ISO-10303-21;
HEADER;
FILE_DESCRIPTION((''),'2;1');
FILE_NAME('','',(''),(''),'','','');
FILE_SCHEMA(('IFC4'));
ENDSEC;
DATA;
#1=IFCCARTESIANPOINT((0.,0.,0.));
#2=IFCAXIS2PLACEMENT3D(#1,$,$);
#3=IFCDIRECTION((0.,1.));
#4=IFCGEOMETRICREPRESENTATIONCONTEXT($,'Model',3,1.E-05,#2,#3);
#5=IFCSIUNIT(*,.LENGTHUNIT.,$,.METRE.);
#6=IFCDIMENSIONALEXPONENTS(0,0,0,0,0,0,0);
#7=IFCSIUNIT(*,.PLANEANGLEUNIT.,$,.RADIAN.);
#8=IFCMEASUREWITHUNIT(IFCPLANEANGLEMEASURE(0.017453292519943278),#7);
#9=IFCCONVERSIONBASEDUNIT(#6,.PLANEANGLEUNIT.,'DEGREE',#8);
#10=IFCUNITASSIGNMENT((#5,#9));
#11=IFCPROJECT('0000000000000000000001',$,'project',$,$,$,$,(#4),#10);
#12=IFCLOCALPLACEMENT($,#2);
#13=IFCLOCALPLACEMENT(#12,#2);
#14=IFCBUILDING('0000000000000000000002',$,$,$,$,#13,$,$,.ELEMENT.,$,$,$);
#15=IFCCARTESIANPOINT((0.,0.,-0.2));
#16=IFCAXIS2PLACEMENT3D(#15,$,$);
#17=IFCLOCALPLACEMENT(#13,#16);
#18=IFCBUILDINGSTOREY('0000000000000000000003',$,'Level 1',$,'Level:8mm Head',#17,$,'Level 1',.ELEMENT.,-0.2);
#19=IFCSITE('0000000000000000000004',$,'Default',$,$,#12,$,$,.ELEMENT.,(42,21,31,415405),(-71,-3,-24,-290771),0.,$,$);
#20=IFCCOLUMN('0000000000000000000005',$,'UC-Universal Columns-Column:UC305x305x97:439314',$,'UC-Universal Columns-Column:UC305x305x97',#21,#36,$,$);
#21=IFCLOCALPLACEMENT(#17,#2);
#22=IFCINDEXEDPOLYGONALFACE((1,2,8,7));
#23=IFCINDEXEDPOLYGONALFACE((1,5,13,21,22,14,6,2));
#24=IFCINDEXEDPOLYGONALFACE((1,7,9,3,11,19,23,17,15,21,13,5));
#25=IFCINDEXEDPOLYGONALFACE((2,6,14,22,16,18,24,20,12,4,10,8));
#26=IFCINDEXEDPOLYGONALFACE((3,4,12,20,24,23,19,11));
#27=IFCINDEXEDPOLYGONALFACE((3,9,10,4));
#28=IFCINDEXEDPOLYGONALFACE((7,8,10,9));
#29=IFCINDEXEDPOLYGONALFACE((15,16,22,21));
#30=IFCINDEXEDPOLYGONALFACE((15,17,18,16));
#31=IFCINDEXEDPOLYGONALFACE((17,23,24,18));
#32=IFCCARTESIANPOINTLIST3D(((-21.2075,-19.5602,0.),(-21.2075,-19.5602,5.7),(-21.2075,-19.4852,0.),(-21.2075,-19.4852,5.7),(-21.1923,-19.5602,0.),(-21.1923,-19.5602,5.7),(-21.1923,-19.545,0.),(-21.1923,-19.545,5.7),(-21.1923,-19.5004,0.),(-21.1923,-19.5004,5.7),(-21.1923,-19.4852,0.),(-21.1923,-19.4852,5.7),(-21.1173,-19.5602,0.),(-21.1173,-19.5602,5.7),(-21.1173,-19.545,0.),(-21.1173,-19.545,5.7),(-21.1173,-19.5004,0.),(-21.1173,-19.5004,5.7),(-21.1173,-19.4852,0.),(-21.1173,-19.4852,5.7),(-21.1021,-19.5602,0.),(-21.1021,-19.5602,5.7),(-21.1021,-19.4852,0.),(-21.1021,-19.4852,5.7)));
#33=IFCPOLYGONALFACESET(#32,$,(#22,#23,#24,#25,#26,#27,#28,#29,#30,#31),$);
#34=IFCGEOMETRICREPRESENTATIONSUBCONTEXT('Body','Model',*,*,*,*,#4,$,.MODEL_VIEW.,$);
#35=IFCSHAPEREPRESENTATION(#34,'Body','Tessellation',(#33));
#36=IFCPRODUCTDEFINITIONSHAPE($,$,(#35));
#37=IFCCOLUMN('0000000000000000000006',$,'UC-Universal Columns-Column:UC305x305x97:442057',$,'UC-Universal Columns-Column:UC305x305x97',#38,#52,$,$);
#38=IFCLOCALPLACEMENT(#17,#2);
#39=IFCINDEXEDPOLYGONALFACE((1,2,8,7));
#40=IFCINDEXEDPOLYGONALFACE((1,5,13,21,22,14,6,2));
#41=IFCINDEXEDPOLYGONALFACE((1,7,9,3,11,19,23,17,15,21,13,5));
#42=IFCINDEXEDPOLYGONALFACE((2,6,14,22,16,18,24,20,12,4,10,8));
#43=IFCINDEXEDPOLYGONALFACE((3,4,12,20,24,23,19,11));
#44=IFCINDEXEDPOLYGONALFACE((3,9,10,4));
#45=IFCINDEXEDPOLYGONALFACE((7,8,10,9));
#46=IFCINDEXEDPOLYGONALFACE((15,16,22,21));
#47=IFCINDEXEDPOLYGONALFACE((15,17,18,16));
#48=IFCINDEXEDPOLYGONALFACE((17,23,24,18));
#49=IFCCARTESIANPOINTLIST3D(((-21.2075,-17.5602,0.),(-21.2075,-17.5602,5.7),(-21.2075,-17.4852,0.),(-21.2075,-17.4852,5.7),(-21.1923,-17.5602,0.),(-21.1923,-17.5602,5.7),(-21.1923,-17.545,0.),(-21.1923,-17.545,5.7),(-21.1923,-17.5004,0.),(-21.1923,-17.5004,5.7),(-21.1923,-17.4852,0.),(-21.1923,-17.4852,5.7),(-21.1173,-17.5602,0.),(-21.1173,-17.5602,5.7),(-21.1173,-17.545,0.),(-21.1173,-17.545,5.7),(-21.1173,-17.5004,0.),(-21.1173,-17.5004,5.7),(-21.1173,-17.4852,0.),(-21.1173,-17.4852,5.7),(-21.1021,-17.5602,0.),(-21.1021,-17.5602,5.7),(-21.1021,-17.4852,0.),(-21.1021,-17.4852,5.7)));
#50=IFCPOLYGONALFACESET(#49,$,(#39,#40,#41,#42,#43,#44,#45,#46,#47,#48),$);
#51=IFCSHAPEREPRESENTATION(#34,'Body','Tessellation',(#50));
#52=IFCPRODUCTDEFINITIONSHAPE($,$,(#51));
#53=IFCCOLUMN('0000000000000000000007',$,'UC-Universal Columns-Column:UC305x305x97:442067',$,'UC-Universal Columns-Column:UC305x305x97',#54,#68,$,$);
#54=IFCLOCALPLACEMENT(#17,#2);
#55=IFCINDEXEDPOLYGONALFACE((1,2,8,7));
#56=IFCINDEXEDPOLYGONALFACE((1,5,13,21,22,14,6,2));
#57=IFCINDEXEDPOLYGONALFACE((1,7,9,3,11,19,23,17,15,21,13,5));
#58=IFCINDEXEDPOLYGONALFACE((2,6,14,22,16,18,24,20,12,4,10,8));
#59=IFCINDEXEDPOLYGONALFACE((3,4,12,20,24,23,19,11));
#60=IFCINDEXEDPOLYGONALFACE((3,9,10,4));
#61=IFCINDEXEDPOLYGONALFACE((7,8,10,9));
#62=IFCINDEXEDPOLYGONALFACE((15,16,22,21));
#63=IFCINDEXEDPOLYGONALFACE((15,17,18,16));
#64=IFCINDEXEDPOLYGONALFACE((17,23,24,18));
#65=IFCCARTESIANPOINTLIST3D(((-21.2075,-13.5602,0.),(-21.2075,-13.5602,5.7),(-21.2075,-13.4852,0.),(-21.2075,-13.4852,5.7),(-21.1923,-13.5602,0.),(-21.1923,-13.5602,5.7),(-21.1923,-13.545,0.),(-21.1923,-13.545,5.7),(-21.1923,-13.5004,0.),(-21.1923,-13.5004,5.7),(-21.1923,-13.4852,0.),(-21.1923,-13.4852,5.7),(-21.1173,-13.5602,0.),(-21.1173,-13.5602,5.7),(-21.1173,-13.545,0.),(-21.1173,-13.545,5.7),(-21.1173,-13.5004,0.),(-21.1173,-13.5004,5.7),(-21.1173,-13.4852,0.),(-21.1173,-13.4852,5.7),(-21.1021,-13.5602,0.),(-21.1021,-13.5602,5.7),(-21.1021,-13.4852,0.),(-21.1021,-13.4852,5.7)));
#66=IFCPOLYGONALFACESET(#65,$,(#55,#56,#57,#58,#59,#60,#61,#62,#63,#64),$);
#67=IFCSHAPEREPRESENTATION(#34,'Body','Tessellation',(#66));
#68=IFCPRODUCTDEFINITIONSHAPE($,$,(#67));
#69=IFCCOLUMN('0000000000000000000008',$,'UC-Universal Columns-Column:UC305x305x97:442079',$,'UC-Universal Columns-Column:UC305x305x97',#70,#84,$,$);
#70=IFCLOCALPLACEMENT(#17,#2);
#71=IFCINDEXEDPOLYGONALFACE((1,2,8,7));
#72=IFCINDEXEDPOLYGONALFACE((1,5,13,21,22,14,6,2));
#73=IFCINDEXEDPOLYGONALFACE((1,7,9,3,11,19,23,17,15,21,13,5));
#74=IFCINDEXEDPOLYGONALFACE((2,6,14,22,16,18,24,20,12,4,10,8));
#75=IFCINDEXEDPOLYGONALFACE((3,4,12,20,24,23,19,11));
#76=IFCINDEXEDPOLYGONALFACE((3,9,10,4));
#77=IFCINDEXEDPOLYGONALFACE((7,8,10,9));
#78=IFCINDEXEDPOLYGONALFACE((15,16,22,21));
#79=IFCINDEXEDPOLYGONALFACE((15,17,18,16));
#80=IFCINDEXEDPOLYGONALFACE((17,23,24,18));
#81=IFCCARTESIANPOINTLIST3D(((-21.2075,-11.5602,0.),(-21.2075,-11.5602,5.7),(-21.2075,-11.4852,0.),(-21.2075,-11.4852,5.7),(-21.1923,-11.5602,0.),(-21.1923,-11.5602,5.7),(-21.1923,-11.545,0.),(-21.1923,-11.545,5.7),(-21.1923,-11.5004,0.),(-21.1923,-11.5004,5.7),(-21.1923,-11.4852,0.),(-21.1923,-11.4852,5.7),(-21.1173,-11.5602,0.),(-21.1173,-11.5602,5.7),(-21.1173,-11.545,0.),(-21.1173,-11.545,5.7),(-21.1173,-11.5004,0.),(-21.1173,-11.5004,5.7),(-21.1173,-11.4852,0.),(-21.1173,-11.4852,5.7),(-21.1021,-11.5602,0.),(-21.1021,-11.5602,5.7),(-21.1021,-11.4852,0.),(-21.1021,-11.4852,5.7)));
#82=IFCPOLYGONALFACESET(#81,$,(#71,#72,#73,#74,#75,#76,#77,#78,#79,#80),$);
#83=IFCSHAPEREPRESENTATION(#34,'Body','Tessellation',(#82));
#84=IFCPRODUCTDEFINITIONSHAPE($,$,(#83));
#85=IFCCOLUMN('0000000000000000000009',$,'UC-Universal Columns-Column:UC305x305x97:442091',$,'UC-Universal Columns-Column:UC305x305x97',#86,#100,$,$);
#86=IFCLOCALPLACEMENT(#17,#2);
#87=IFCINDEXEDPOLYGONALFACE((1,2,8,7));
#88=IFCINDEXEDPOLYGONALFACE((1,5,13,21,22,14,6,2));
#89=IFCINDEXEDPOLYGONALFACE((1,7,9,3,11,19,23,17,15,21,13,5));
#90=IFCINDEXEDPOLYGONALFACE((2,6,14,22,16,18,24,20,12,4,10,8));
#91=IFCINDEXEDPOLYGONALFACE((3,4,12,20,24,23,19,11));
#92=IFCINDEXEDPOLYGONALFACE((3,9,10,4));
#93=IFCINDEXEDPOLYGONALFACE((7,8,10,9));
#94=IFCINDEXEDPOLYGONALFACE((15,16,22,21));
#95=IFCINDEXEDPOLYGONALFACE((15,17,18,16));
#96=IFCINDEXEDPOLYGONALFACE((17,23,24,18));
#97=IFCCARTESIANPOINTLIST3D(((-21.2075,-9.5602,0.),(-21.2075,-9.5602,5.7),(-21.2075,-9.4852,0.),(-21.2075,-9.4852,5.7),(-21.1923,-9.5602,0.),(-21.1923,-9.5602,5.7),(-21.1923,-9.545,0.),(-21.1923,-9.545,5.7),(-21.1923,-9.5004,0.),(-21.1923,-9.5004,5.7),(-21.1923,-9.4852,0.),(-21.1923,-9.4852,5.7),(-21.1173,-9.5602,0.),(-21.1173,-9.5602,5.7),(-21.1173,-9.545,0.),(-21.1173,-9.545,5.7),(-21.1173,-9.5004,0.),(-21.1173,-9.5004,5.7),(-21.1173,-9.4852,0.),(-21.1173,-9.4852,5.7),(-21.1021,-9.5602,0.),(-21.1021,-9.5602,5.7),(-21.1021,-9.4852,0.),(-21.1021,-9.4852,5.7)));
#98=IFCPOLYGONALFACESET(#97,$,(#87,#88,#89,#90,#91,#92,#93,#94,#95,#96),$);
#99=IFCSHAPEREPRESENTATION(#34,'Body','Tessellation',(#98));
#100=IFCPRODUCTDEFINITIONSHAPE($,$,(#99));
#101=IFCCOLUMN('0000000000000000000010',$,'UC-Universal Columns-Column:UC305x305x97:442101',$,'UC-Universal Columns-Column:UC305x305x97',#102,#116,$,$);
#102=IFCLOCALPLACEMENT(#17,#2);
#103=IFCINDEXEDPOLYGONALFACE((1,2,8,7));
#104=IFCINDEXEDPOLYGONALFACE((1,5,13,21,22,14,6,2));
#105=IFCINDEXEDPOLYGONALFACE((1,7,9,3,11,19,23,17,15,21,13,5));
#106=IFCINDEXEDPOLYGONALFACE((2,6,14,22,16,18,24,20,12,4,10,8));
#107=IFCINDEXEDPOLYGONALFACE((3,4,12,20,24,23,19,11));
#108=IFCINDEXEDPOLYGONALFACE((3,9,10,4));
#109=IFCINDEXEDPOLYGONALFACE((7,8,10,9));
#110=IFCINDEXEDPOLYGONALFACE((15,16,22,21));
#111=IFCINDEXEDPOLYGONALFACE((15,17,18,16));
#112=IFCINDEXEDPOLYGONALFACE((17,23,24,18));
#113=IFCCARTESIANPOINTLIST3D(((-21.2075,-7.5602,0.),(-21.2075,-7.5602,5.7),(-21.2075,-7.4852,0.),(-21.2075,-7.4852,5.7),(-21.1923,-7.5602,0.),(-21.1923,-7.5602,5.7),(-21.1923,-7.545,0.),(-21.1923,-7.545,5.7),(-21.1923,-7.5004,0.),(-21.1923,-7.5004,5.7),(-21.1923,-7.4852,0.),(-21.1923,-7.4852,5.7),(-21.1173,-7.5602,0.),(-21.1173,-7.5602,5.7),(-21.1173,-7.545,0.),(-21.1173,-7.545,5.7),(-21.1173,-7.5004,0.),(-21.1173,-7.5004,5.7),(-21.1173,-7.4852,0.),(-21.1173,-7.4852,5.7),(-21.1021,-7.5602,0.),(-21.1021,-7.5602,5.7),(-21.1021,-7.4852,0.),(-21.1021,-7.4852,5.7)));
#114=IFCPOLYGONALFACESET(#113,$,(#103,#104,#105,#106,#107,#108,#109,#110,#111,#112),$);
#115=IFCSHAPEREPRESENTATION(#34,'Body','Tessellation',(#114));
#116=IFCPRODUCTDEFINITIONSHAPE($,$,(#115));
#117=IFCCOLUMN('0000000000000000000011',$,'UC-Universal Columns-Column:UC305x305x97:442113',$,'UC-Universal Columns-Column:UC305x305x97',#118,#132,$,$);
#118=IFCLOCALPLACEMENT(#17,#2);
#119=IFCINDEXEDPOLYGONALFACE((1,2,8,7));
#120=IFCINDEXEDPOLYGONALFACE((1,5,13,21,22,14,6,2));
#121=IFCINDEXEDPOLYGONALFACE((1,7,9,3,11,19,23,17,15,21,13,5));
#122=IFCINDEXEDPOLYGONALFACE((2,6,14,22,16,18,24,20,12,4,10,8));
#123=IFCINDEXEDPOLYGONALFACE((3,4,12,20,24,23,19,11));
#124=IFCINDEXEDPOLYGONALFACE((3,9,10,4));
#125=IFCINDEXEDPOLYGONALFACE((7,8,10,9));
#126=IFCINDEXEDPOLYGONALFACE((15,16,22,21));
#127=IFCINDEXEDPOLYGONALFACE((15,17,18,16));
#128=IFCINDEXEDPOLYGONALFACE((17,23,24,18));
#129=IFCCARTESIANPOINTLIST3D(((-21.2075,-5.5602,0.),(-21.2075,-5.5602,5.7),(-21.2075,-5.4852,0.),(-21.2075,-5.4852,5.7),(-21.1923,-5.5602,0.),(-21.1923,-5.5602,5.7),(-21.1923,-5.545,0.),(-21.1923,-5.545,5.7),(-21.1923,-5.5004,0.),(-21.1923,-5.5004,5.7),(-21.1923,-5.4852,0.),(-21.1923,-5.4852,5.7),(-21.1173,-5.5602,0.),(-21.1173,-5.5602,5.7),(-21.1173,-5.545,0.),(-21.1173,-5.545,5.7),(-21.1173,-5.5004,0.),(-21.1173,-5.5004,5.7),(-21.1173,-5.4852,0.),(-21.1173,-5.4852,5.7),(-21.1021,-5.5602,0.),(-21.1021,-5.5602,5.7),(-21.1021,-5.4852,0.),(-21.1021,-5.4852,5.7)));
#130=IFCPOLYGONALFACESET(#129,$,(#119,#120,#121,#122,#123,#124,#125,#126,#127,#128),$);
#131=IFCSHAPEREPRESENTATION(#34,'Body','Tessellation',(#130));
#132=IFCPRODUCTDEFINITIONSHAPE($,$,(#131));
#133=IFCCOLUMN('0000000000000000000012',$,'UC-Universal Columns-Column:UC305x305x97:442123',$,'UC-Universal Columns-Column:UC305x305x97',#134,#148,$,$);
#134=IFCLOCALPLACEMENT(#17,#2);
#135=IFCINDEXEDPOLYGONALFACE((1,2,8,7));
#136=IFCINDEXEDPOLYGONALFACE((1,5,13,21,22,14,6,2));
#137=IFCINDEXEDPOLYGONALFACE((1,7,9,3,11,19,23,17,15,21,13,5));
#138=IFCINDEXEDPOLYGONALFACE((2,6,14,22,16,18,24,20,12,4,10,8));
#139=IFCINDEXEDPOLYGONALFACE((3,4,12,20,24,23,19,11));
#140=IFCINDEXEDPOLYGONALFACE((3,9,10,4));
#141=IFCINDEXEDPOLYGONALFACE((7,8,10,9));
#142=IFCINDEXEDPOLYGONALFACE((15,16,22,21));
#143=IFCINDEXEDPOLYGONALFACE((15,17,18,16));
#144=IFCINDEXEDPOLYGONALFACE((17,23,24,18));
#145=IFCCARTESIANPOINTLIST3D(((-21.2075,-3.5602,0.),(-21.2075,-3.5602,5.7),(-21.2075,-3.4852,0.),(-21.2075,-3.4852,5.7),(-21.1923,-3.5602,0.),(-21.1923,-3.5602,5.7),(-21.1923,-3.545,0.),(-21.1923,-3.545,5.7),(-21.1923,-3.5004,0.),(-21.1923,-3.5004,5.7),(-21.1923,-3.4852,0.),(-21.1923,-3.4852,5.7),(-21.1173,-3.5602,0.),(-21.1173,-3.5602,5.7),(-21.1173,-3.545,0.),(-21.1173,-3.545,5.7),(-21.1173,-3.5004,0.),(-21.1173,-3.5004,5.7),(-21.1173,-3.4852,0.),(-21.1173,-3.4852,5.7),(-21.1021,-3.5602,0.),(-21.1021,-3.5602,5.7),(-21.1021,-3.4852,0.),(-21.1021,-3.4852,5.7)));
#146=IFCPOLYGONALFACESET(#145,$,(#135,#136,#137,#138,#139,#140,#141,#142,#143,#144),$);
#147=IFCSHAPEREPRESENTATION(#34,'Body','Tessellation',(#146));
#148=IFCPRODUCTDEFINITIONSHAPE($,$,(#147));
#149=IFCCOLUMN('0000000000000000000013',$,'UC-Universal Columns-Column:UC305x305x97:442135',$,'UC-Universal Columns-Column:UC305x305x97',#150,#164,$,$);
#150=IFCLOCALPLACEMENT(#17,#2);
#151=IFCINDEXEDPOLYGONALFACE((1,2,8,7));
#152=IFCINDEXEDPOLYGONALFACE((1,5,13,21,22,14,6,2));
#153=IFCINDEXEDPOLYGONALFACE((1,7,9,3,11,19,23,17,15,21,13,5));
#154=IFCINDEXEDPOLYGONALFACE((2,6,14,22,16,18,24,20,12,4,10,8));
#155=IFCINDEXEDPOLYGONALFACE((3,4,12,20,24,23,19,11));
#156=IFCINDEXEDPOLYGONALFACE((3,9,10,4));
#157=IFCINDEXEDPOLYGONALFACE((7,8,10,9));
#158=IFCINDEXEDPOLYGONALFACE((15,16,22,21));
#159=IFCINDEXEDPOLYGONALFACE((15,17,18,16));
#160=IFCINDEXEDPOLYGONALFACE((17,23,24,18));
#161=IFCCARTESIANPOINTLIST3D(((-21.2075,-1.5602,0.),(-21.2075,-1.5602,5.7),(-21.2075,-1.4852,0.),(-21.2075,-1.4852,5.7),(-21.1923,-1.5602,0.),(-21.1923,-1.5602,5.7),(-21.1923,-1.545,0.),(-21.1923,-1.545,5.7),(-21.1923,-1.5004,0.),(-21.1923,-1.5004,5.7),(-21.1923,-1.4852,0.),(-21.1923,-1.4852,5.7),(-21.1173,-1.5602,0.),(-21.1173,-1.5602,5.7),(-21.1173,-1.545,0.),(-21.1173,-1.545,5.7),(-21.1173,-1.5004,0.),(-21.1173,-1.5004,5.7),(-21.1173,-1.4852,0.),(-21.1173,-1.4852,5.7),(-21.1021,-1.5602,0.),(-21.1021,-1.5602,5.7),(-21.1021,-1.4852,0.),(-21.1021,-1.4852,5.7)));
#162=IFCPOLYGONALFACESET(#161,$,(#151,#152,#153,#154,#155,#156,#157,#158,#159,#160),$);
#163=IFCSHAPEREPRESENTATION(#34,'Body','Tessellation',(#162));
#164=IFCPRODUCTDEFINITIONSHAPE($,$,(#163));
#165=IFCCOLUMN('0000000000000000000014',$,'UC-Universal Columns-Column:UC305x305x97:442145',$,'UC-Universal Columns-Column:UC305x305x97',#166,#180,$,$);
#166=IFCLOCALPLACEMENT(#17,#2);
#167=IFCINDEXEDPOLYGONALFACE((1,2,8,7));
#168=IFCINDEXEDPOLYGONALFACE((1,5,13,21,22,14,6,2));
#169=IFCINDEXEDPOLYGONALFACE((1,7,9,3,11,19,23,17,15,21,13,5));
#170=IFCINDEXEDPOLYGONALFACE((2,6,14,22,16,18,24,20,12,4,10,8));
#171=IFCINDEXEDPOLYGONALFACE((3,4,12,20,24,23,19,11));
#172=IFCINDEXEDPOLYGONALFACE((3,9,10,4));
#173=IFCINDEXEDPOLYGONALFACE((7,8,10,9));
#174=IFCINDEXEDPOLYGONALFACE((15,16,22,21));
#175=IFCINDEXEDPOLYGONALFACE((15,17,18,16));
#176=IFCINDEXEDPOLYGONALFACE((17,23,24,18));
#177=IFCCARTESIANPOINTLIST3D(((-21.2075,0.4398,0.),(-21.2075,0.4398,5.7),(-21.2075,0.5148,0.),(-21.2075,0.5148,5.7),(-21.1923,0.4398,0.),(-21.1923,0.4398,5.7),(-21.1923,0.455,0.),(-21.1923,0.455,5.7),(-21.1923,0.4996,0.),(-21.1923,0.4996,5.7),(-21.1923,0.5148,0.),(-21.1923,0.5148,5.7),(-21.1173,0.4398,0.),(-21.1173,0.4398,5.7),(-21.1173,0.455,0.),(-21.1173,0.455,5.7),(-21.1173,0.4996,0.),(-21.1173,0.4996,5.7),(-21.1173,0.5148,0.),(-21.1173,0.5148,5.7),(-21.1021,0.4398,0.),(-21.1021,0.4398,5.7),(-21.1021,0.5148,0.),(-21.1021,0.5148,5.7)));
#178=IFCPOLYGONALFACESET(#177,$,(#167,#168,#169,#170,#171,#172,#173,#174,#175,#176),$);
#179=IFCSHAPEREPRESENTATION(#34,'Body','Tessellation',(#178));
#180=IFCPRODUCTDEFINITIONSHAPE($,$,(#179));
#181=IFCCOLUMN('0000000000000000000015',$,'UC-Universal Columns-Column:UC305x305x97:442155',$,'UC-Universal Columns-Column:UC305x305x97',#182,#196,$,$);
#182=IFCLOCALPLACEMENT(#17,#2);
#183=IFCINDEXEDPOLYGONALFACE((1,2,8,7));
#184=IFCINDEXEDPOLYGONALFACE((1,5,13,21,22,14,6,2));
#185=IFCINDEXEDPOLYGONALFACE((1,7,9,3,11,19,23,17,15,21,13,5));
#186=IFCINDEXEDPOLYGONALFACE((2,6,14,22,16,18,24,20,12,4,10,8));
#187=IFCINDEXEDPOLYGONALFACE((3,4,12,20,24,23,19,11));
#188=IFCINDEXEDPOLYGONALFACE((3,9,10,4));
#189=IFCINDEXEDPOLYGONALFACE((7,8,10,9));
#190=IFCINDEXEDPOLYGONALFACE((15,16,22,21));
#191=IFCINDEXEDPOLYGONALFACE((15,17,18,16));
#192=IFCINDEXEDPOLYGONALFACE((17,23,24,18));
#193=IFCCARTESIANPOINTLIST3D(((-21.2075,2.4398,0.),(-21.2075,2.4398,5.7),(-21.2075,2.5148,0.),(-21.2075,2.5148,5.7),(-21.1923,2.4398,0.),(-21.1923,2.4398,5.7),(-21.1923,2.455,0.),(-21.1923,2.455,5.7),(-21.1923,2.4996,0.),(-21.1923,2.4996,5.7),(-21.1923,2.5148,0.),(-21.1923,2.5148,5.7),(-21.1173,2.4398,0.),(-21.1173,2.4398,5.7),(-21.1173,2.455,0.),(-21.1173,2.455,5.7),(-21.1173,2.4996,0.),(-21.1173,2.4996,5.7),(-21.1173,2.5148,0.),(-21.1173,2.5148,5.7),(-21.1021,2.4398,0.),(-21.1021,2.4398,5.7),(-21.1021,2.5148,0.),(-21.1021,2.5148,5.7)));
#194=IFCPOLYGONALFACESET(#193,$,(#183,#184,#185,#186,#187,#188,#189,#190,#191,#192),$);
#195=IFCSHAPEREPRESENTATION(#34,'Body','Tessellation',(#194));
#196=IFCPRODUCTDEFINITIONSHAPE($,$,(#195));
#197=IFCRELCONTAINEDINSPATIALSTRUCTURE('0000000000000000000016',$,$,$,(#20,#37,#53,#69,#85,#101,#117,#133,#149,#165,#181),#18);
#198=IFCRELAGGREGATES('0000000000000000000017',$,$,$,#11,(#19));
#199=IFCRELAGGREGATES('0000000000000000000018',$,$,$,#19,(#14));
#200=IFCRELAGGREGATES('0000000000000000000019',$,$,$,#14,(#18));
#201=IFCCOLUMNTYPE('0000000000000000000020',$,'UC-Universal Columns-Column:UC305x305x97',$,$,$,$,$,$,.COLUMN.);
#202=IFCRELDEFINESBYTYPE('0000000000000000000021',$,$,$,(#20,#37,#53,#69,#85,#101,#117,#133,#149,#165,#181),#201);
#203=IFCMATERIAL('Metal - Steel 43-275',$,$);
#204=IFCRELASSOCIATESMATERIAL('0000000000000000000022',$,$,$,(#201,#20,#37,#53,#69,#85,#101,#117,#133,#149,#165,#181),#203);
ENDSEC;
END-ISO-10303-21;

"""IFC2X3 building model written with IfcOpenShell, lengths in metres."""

from ifc_helpers import new_model, entity, si_unit, converted_unit, direction, frame, frame_2d, origin, place, context, subcontext, project, spatial, polyline, circle_curve, parameter, trimmed, segment, composite_curve, outline, extrude, source, transform, mapped, material, type_object, type_shapes, element, save


model = new_model("IFC2X3")

# Units and contexts
model_context = context("Model", 3, precision=1e-05, world=origin(), true_north=direction((0.0, 1.0)))
body_context = subcontext(model_context, "Body", "Model", "MODEL_VIEW")
ifc_project = project(units=[si_unit("LENGTHUNIT", "METRE"), converted_unit("PLANEANGLEUNIT", "DEGREE", entity("IfcPlaneAngleMeasure", 0.017453292519943278), si_unit("PLANEANGLEUNIT", "RADIAN"), dimensions=[0, 0, 0, 0, 0, 0, 0])], contexts=[model_context])

# Site, building, storey
site_placement = place(None, origin())
site = spatial("IfcSite", under=ifc_project, at=site_placement, Name="Default", CompositionType="ELEMENT", RefLatitude=(42, 21, 31, 415405), RefLongitude=(-71, -3, -24, -290771), RefElevation=0.0)
building_placement = place(site_placement, origin())
building = spatial("IfcBuilding", under=site, at=building_placement, CompositionType="ELEMENT")
storey_placement = place(building_placement, frame((0.0, 0.0, -0.2)))
storey = spatial("IfcBuildingStorey", under=building, at=storey_placement, Name="Level 1", ObjectType="Level:8mm Head", LongName="Level 1", CompositionType="ELEMENT", Elevation=-0.2)

# Columns
ifc_material_1 = material(Name="Metal - Steel 43-275")
column_type_1 = type_object("IfcColumnType", Name="UC-Universal Columns-Column:UC305x305x97", PredefinedType="COLUMN", material=ifc_material_1)
shared_shape_1 = source(origin(), body_context, "Body", "SweptSolid", [
    extrude(outline(composite_curve([segment(polyline([(-0.0375, -0.0375), (0.0375, -0.0375)]), True, "CONTINUOUS"), segment(polyline([(0.0375, -0.0375), (0.0527, -0.0375)]), True, "CONTINUOUS"), segment(trimmed(circle_curve(frame_2d((0.0527, -0.0223), x_axis=(-1.0, 0.0)), 0.0152), [parameter(0.0)], [parameter(90.0)], True, "PARAMETER"), False, "CONTINUOUS"), segment(polyline([(0.0375, -0.0223), (0.0375, 0.0223)]), True, "CONTINUOUS"), segment(trimmed(circle_curve(frame_2d((0.0527, 0.0223), x_axis=(-1.0, 0.0)), 0.0152), [parameter(270.0)], [parameter(0.0)], True, "PARAMETER"), False, "CONTINUOUS"), segment(polyline([(0.0527, 0.0375), (0.0375, 0.0375)]), True, "CONTINUOUS"), segment(polyline([(0.0375, 0.0375), (-0.0375, 0.0375)]), True, "CONTINUOUS"), segment(polyline([(-0.0375, 0.0375), (-0.0527, 0.0375)]), True, "CONTINUOUS"), segment(trimmed(circle_curve(frame_2d((-0.0527, 0.0223), x_axis=(-1.0, 0.0)), 0.0152), [parameter(180.0)], [parameter(270.0)], True, "PARAMETER"), False, "CONTINUOUS"), segment(polyline([(-0.0375, 0.0223), (-0.0375, -0.0223)]), True, "CONTINUOUS"), segment(trimmed(circle_curve(frame_2d((-0.0527, -0.0223), x_axis=(-1.0, 0.0)), 0.0152), [parameter(90.0)], [parameter(180.0)], True, "PARAMETER"), False, "CONTINUOUS"), segment(polyline([(-0.0527, -0.0375), (-0.0375, -0.0375)]), True, "CONTINUOUS")], self_intersect=False)), frame((0.0, 0.0, -0.2), z_axis=(0.0, 0.0, 1.0), x_axis=(-1.0, 0.0, 0.0)), (0.0, 0.0, 1.0), 5.7),
])
type_shapes(column_type_1, [shared_shape_1])
for number, where, z_axis, x_axis, name in (
    (1, (-21.1548, -19.5227, 0.2), (0.0, 0.0, 1.0), (-1.0, 0.0, 0.0), "UC-Universal Columns-Column:UC305x305x97:439314"),
    (2, (-21.1548, -17.5227, 0.2), (0.0, 0.0, 1.0), (-1.0, 0.0, 0.0), "UC-Universal Columns-Column:UC305x305x97:442057"),
    (3, (-21.1548, -13.5227, 0.2), (0.0, 0.0, 1.0), (-1.0, 0.0, 0.0), "UC-Universal Columns-Column:UC305x305x97:442067"),
    (4, (-21.1548, -11.5227, 0.2), (0.0, 0.0, 1.0), (-1.0, 0.0, 0.0), "UC-Universal Columns-Column:UC305x305x97:442079"),
    (5, (-21.1548, -9.5227, 0.2), (0.0, 0.0, 1.0), (-1.0, 0.0, 0.0), "UC-Universal Columns-Column:UC305x305x97:442091"),
    (6, (-21.1548, -7.5227, 0.2), (0.0, 0.0, 1.0), (-1.0, 0.0, 0.0), "UC-Universal Columns-Column:UC305x305x97:442101"),
    (7, (-21.1548, -5.5227, 0.2), (0.0, 0.0, 1.0), (-1.0, 0.0, 0.0), "UC-Universal Columns-Column:UC305x305x97:442113"),
    (8, (-21.1548, -3.5227, 0.2), (0.0, 0.0, 1.0), (-1.0, 0.0, 0.0), "UC-Universal Columns-Column:UC305x305x97:442123"),
    (9, (-21.1548, -1.5227, 0.2), (0.0, 0.0, 1.0), (-1.0, 0.0, 0.0), "UC-Universal Columns-Column:UC305x305x97:442135"),
    (10, (-21.1548, 0.4773, 0.2), (0.0, 0.0, 1.0), (-1.0, 0.0, 0.0), "UC-Universal Columns-Column:UC305x305x97:442145"),
    (11, (-21.1548, 2.4773, 0.2), (0.0, 0.0, 1.0), (-1.0, 0.0, 0.0), "UC-Universal Columns-Column:UC305x305x97:442155"),
):
    element("IfcColumn", number, at=place(storey_placement, frame(where, z_axis=z_axis, x_axis=x_axis)), inside=storey, type_object=column_type_1, material=ifc_material_1, Name=name, ObjectType="UC-Universal Columns-Column:UC305x305x97", context=body_context, shape_type="MappedRepresentation", body=[
        mapped(shared_shape_1, transform((0.0, 0.0, 0.0), scale=1.0)),
    ])

save(model, "model.ifc")
